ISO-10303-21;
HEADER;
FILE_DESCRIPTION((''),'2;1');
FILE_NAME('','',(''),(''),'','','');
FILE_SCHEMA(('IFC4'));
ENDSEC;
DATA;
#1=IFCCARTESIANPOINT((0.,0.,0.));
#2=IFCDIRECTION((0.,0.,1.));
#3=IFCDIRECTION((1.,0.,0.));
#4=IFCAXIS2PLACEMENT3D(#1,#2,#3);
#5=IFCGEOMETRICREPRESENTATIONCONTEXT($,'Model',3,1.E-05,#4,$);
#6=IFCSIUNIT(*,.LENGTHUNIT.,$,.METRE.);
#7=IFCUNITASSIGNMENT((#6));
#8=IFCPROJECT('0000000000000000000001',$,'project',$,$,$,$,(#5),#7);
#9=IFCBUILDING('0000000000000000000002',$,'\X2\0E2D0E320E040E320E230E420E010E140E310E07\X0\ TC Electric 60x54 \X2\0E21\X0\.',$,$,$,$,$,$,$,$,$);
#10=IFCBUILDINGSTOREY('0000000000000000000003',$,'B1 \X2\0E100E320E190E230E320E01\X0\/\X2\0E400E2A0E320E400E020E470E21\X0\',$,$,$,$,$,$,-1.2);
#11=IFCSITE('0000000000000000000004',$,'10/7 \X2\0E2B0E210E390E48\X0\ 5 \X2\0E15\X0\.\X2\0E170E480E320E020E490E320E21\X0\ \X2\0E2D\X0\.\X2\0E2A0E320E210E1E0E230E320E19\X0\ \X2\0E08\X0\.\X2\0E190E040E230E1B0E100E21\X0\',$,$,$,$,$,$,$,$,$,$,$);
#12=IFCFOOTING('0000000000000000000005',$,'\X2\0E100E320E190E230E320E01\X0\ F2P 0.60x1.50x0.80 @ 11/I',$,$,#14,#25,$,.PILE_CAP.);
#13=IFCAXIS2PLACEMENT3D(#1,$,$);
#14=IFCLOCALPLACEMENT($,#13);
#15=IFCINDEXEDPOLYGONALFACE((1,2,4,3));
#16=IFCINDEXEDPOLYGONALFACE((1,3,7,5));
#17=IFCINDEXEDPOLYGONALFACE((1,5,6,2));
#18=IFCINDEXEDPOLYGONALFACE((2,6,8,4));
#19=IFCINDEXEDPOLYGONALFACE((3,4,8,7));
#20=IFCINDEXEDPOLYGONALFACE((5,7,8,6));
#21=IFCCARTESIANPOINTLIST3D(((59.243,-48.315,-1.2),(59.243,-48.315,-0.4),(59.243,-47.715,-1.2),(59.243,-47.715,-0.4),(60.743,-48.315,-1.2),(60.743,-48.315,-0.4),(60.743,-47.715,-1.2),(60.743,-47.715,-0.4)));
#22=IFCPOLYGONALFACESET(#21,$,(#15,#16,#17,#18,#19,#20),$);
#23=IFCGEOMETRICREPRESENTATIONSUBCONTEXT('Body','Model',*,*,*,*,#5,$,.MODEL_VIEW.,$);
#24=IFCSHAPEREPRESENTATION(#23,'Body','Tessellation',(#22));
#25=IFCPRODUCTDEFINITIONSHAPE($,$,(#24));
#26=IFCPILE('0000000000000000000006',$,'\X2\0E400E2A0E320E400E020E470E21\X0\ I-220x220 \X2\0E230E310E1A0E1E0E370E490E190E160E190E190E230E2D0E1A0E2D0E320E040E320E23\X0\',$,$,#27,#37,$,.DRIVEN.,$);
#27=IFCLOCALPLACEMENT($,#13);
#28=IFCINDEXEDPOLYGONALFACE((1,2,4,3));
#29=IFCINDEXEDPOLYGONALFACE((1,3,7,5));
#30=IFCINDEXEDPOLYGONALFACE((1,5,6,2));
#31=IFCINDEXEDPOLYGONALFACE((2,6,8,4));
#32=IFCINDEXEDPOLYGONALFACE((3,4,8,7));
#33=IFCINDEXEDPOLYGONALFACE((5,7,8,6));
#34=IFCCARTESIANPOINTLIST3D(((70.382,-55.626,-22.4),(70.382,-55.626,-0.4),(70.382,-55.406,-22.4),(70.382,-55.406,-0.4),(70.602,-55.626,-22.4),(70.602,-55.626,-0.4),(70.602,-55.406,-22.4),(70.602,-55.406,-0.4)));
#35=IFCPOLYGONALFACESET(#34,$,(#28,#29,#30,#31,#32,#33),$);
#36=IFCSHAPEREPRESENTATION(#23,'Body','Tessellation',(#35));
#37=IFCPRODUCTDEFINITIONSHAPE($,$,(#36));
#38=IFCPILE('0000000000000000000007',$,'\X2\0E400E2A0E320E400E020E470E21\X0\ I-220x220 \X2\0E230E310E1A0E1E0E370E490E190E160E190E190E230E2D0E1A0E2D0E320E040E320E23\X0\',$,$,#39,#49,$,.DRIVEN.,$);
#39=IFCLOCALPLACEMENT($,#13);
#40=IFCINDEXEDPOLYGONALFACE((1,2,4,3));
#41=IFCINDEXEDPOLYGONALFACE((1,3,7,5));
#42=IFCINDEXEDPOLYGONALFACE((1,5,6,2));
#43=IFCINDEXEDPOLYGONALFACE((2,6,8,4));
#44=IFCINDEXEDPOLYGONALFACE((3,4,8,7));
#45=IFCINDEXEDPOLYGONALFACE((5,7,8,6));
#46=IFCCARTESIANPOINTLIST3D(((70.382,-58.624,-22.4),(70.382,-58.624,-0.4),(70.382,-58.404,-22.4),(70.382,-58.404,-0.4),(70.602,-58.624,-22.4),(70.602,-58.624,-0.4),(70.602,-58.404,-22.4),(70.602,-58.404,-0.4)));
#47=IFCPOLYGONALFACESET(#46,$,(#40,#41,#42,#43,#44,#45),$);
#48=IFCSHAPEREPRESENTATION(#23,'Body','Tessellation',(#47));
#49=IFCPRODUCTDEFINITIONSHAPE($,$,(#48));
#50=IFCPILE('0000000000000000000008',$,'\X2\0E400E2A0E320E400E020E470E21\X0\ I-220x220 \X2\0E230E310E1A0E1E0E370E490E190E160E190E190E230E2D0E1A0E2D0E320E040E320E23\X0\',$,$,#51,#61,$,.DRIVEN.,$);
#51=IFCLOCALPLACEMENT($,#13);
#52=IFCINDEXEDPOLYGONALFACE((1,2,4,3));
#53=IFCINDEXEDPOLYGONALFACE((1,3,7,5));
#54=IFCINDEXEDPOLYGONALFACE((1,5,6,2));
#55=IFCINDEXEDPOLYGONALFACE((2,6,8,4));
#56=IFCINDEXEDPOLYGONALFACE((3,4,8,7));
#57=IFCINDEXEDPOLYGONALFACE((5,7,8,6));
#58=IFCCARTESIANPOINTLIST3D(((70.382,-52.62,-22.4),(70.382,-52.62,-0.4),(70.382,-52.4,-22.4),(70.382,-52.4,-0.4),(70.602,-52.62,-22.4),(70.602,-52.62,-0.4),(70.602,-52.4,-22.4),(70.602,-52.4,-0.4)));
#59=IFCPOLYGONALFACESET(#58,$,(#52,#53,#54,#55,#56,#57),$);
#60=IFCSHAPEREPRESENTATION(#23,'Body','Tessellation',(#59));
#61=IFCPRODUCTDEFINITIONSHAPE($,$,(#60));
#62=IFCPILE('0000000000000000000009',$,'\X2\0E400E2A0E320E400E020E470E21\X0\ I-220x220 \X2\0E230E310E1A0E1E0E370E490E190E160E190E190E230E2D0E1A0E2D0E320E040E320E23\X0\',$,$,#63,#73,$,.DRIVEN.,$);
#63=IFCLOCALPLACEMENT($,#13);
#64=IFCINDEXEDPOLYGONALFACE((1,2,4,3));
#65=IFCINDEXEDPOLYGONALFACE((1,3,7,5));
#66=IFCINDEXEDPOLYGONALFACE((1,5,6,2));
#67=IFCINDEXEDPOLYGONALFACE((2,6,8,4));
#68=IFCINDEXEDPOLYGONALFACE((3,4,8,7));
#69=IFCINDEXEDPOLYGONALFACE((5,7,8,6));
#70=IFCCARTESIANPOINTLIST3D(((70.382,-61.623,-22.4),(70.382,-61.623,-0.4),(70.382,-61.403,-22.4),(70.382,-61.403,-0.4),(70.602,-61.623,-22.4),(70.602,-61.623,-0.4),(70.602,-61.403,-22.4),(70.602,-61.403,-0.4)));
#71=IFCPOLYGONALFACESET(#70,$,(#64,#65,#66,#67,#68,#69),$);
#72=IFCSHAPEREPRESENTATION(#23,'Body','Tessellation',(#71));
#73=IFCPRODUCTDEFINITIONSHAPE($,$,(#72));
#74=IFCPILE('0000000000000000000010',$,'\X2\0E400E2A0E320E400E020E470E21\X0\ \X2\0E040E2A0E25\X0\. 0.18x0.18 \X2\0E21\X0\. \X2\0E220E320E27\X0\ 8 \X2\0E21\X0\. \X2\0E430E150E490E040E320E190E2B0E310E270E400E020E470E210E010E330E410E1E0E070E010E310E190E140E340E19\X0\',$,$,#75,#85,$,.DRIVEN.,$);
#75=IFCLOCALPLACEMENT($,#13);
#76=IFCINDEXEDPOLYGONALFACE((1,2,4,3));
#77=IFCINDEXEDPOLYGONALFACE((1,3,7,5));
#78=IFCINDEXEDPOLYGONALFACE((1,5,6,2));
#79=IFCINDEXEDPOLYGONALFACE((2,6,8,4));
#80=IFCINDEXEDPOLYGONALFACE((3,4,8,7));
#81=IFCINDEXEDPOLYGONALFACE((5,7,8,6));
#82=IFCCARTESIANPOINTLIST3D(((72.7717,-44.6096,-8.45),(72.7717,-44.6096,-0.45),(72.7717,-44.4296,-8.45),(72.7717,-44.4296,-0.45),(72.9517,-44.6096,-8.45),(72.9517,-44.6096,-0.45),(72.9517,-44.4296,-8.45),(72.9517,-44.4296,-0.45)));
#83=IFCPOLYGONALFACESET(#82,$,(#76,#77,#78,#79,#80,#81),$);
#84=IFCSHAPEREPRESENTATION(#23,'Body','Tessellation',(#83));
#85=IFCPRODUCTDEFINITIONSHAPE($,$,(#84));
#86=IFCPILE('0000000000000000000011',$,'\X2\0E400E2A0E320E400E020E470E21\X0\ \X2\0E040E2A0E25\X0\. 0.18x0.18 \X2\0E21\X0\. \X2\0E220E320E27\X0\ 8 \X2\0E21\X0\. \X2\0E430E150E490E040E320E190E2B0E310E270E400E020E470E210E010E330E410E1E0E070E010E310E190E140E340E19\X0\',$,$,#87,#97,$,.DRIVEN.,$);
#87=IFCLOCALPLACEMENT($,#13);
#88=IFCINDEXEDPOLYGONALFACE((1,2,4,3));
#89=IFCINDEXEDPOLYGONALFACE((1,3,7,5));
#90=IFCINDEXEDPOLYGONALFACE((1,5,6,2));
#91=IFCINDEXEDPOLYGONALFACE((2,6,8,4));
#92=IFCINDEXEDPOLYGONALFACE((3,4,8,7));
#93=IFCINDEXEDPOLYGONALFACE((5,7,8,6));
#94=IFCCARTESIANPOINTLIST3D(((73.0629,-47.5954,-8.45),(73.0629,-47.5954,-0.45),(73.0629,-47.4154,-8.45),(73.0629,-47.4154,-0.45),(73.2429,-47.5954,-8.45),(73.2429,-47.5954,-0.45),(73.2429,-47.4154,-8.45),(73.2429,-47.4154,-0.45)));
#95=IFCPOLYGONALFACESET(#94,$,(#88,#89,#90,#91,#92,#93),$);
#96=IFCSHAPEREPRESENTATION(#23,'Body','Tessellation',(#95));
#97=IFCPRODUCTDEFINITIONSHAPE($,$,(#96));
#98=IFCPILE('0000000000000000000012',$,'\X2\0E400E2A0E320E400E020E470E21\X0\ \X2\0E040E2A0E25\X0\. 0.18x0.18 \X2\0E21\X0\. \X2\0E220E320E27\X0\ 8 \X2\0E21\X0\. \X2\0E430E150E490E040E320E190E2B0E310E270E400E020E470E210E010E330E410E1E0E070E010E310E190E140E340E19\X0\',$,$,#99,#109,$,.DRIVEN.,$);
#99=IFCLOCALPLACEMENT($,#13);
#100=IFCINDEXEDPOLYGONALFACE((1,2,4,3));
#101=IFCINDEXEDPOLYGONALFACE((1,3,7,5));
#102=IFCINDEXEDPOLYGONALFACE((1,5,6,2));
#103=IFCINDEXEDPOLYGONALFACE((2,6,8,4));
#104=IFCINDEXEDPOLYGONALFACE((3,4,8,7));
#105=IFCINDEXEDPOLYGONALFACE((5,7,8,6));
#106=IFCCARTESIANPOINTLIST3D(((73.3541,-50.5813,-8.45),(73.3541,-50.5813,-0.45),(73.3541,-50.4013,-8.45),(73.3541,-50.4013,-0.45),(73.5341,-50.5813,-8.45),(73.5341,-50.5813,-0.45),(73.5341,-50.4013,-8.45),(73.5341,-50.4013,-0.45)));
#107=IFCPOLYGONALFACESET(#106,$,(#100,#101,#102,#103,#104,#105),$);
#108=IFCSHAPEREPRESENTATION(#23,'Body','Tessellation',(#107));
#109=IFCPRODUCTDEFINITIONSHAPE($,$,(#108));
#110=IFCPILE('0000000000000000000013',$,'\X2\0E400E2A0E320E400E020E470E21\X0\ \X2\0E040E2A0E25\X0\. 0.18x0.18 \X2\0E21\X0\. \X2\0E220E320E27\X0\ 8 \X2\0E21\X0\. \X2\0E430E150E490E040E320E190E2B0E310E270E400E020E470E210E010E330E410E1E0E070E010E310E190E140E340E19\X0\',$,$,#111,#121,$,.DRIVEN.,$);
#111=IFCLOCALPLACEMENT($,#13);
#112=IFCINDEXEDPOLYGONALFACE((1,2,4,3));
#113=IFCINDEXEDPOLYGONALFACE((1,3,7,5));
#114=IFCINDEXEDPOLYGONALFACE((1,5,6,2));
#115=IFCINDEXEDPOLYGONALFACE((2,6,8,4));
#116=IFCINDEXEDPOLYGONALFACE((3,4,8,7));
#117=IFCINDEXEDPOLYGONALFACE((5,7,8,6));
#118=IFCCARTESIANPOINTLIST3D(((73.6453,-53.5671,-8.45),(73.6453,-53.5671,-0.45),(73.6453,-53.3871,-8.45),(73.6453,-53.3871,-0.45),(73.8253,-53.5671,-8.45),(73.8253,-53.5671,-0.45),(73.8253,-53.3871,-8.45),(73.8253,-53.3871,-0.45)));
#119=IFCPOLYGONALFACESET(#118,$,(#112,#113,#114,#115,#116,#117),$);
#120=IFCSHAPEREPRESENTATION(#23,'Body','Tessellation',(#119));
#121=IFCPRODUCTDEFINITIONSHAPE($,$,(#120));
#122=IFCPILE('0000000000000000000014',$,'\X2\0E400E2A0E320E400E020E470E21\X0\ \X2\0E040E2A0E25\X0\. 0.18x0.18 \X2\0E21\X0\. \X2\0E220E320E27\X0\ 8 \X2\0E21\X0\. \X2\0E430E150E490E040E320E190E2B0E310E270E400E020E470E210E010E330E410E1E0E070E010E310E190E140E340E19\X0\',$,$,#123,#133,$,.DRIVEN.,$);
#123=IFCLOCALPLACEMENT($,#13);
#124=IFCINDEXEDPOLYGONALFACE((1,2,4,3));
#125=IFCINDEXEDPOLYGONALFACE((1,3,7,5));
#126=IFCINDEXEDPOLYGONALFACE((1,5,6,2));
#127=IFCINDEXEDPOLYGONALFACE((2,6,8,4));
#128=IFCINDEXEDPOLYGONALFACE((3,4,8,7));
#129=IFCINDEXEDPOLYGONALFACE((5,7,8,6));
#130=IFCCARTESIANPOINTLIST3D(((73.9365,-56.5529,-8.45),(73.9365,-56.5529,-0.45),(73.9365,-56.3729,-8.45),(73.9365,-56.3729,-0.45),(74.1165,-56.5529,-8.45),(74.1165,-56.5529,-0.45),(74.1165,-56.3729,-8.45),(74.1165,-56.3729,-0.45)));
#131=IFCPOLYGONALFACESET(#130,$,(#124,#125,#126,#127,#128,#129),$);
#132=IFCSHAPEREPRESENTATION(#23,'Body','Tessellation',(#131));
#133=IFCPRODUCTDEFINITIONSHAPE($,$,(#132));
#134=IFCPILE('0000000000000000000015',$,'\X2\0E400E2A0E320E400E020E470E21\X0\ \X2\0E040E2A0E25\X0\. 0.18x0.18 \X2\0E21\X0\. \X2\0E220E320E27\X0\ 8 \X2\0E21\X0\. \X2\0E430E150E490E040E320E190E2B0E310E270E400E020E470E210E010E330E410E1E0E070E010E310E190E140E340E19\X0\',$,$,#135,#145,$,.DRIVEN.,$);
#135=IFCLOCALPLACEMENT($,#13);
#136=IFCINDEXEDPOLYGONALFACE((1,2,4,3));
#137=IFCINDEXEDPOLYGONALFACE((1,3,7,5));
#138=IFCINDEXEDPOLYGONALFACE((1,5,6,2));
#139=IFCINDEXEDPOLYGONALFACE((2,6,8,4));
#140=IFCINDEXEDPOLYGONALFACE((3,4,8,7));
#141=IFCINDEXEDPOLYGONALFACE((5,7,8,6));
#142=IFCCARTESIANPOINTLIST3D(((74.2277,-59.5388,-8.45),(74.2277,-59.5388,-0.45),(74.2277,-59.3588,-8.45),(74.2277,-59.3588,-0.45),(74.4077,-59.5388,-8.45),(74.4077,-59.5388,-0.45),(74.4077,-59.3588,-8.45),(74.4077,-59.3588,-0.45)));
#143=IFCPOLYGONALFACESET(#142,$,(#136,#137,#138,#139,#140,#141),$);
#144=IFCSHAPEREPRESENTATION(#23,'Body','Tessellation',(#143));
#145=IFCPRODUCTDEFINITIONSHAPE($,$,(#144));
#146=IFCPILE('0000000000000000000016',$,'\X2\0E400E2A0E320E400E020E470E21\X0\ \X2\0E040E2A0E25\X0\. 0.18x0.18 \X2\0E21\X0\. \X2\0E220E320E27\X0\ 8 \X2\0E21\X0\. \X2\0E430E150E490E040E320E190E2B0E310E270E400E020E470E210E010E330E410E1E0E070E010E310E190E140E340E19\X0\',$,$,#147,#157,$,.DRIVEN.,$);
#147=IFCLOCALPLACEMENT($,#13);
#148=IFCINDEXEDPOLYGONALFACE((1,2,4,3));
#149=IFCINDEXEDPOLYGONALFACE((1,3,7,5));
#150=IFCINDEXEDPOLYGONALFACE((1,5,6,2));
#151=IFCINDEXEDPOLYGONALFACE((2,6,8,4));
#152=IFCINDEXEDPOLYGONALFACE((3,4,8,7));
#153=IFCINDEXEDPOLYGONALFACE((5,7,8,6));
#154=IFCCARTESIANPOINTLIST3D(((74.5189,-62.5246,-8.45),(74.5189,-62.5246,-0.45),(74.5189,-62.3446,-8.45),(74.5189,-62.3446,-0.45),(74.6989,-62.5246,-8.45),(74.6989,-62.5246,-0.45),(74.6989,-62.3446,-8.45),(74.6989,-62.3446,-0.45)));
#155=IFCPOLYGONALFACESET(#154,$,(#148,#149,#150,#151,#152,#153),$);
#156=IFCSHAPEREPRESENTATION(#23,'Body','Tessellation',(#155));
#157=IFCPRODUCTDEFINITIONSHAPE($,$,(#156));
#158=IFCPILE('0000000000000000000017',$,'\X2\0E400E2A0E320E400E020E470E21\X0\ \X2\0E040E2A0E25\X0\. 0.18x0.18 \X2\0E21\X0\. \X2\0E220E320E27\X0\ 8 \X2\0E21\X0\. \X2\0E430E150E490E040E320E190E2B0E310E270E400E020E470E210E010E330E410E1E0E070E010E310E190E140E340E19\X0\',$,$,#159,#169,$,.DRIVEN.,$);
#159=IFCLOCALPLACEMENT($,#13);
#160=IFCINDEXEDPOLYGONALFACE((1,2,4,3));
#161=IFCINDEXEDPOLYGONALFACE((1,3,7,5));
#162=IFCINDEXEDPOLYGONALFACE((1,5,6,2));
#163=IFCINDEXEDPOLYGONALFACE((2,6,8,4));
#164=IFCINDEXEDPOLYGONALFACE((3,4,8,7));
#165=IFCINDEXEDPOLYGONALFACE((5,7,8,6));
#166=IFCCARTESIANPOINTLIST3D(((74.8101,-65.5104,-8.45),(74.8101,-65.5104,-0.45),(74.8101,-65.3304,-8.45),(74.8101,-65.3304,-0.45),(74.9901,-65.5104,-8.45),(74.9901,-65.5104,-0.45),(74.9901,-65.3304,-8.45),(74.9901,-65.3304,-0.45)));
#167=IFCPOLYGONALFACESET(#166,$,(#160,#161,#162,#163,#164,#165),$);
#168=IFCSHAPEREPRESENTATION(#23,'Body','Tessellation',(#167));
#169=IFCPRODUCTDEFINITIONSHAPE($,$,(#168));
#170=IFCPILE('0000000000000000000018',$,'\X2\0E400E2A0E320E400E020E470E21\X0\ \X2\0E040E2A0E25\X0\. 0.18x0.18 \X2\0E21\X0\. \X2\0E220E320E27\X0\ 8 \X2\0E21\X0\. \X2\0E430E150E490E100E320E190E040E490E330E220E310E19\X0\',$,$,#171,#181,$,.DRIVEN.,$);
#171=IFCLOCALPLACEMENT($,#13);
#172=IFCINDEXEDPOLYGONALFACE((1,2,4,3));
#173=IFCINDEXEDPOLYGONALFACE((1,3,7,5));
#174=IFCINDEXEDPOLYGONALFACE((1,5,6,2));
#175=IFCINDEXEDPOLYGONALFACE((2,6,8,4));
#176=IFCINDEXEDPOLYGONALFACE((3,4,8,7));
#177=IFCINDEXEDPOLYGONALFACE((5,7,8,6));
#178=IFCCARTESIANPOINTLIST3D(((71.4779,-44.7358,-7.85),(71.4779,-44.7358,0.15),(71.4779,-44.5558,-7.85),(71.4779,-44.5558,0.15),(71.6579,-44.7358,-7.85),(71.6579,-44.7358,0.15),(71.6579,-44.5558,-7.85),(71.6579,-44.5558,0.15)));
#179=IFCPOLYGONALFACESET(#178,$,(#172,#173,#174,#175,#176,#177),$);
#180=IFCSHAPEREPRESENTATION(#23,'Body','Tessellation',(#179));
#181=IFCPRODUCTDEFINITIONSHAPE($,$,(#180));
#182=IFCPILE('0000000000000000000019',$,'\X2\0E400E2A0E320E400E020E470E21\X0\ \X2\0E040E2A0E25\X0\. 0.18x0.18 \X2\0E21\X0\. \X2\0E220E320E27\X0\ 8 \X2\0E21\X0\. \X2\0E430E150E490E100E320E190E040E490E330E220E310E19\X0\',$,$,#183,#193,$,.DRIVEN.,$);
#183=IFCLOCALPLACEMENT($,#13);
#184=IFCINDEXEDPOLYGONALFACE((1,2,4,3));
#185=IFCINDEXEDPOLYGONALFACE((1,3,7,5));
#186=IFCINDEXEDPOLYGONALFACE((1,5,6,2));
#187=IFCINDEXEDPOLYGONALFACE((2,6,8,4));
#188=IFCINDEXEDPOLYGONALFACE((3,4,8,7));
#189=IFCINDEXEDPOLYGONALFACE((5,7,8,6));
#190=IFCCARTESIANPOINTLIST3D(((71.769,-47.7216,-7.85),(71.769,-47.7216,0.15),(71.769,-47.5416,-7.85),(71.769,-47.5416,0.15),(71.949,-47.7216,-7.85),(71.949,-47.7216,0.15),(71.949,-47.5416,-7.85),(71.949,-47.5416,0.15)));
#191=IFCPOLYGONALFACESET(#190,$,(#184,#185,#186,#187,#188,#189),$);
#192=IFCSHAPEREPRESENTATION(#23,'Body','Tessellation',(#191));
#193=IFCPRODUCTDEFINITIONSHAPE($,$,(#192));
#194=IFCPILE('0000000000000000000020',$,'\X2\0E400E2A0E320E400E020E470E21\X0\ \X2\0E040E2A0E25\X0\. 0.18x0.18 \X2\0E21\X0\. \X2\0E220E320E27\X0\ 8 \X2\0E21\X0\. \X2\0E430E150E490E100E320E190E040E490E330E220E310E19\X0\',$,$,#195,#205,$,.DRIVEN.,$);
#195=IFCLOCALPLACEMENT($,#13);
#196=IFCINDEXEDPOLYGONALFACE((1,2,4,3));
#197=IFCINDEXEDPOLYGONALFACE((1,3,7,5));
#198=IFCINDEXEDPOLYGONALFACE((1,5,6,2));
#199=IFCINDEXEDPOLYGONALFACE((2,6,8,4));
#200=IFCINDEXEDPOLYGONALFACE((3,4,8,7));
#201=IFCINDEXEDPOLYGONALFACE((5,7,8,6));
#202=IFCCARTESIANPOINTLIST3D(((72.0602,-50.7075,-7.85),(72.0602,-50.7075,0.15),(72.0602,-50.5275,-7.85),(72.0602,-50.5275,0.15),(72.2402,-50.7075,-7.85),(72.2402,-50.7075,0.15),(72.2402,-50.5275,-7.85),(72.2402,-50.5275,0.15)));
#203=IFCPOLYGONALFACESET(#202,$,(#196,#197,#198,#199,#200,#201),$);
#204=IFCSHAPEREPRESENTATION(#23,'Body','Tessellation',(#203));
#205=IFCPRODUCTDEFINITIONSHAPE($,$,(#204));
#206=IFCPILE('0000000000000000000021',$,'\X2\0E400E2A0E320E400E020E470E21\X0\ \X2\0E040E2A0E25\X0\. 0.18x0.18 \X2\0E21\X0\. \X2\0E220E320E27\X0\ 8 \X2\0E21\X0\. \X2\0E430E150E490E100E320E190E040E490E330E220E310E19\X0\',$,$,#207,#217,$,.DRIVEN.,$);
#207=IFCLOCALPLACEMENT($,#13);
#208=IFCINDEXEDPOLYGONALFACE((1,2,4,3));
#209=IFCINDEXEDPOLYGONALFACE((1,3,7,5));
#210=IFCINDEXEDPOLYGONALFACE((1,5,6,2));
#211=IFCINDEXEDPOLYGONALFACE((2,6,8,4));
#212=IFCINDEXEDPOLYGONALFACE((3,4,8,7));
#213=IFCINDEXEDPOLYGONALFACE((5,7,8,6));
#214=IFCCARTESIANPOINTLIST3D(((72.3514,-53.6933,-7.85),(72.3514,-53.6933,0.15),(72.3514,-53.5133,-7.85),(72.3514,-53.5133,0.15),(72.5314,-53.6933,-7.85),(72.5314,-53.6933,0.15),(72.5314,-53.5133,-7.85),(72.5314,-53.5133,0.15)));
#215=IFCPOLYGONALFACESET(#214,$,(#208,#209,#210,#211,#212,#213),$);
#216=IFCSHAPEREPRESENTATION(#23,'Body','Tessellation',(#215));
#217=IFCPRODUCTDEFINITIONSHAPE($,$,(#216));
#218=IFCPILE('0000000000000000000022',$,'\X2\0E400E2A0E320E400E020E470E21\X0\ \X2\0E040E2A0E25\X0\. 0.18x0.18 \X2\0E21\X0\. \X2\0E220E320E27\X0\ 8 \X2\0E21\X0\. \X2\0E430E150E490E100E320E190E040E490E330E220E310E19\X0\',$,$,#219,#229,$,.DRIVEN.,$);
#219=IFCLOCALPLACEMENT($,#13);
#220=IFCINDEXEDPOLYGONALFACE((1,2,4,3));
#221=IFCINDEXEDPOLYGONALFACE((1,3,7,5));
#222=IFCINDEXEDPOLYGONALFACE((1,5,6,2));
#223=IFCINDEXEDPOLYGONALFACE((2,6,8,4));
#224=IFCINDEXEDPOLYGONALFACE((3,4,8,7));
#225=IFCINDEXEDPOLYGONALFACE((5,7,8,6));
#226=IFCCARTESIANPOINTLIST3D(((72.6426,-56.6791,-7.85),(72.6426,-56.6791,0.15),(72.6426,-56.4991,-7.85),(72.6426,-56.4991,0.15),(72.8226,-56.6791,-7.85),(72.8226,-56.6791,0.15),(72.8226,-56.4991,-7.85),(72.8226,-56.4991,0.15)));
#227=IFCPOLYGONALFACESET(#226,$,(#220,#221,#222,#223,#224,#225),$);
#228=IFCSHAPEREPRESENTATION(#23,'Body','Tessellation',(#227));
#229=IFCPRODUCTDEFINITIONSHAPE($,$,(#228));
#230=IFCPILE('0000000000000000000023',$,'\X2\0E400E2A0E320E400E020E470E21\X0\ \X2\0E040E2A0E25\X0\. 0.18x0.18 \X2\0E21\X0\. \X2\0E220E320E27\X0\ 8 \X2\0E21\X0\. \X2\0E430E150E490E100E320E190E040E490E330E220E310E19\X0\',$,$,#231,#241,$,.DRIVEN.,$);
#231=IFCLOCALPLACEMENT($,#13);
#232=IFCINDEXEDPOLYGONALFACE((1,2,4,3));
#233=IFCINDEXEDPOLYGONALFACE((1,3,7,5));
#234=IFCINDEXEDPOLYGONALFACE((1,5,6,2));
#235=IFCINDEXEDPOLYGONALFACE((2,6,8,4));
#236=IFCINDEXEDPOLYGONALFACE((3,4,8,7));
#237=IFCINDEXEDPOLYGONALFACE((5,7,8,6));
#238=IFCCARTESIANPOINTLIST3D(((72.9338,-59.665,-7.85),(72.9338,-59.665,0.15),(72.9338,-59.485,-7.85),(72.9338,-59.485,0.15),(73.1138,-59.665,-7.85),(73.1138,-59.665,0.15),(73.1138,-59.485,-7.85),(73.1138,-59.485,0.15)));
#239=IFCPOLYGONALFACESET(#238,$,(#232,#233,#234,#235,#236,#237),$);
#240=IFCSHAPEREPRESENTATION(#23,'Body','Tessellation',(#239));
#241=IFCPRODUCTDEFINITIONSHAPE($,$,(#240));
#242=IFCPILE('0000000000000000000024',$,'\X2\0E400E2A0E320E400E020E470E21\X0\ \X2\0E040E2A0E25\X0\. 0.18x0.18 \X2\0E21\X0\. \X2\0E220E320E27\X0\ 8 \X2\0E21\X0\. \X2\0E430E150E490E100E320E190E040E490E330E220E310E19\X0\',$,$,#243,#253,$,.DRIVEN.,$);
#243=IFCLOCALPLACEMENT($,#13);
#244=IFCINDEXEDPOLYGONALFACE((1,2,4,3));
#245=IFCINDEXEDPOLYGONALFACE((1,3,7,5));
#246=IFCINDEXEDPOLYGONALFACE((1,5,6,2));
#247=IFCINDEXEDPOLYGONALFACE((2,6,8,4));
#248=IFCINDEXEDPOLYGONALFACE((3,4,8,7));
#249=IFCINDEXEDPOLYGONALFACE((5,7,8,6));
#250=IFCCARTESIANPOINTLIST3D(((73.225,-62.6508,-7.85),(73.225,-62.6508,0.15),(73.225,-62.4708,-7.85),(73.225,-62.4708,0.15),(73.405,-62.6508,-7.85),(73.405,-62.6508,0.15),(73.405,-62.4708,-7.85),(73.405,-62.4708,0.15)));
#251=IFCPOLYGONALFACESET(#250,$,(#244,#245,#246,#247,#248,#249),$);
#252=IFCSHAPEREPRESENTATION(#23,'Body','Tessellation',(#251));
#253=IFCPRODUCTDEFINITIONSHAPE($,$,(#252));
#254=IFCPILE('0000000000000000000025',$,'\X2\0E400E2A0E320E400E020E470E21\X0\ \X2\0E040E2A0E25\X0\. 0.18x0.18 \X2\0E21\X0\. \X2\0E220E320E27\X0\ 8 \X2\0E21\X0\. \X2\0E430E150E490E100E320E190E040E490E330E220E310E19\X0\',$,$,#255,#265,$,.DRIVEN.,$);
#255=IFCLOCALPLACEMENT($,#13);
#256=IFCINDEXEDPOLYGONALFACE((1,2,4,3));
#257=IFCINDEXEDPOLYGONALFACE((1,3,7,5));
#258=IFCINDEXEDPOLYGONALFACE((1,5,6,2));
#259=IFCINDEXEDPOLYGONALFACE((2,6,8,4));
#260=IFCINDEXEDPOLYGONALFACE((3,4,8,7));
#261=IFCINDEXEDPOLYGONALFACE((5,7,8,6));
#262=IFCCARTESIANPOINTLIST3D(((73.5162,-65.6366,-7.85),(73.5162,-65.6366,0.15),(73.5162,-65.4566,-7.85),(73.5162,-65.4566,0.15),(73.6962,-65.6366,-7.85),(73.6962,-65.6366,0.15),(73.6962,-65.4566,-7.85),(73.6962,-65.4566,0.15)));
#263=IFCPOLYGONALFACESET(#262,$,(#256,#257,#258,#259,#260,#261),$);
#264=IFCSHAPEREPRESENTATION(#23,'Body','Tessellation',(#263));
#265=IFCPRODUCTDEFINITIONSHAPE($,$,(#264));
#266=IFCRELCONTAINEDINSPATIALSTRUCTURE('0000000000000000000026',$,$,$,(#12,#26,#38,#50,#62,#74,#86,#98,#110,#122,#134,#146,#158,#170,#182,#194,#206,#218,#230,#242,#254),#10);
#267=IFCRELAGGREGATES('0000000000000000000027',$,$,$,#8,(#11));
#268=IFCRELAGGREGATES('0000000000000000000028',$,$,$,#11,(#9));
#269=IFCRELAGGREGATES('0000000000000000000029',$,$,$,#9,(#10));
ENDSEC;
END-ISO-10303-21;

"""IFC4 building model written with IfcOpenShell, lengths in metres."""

from ifc_helpers import new_model, si_unit, frame, origin, origin_with_axes, origin_2d, place, context, subcontext, project, spatial, rectangle, extrude, element, save


model = new_model("IFC4")

# Units and contexts
model_context = context("Model", 3, precision=1e-05, world=origin_with_axes())
body_context = subcontext(model_context, "Body", "Model", "MODEL_VIEW")
ifc_project = project(units=[si_unit("LENGTHUNIT", "METRE")], contexts=[model_context])

# Site, building, storey
site = spatial("IfcSite", under=ifc_project, Name="10/7 หมู่ 5 ต.ท่าข้าม อ.สามพราน จ.นครปฐม")
building = spatial("IfcBuilding", under=site, Name="อาคารโกดัง TC Electric 60x54 ม.")
storey = spatial("IfcBuildingStorey", under=building, Name="B1 ฐานราก/เสาเข็ม", Elevation=-1.2)

# Footing
footing_placement = place(None, frame((59.993, -48.015, -1.2), z_axis=(0.0, 0.0, 1.0), x_axis=(1.0, 0.0, 0.0)))
element("IfcFooting", 1, at=footing_placement, inside=storey, Name="ฐานราก F2P 0.60x1.50x0.80 @ 11/I", PredefinedType="PILE_CAP", context=body_context, shape_type="SweptSolid", body=[
    extrude(rectangle(XDim=1.5, YDim=0.6, at=origin_2d()), origin(), (0.0, 0.0, 1.0), 0.8),
])

# Piles
for number, where, z_axis, x_axis, name in (
    (2, (70.492, -55.516, -22.4), (0.0, 0.0, 1.0), (1.0, 0.0, 0.0), "เสาเข็ม I-220x220 รับพื้นถนนรอบอาคาร"),
    (3, (70.492, -58.514, -22.4), (0.0, 0.0, 1.0), (1.0, 0.0, 0.0), "เสาเข็ม I-220x220 รับพื้นถนนรอบอาคาร"),
    (4, (70.492, -52.51, -22.4), (0.0, 0.0, 1.0), (1.0, 0.0, 0.0), "เสาเข็ม I-220x220 รับพื้นถนนรอบอาคาร"),
    (5, (70.492, -61.513, -22.4), (0.0, 0.0, 1.0), (1.0, 0.0, 0.0), "เสาเข็ม I-220x220 รับพื้นถนนรอบอาคาร"),
):
    element("IfcPile", number, at=place(None, frame(where, z_axis=z_axis, x_axis=x_axis)), inside=storey, Name=name, PredefinedType="DRIVEN", context=body_context, shape_type="SweptSolid", body=[
        extrude(rectangle(XDim=0.22, YDim=0.22, at=origin_2d()), origin(), (0.0, 0.0, 1.0), 22.0),
    ])
for number, where, z_axis, x_axis, name in (
    (6, (72.8617, -44.5196, -8.45), (0.0, 0.0, 1.0), (1.0, 0.0, 0.0), "เสาเข็ม คสล. 0.18x0.18 ม. ยาว 8 ม. ใต้คานหัวเข็มกำแพงกันดิน"),
    (7, (73.1529, -47.5054, -8.45), (0.0, 0.0, 1.0), (1.0, 0.0, 0.0), "เสาเข็ม คสล. 0.18x0.18 ม. ยาว 8 ม. ใต้คานหัวเข็มกำแพงกันดิน"),
    (8, (73.4441, -50.4913, -8.45), (0.0, 0.0, 1.0), (1.0, 0.0, 0.0), "เสาเข็ม คสล. 0.18x0.18 ม. ยาว 8 ม. ใต้คานหัวเข็มกำแพงกันดิน"),
    (9, (73.7353, -53.4771, -8.45), (0.0, 0.0, 1.0), (1.0, 0.0, 0.0), "เสาเข็ม คสล. 0.18x0.18 ม. ยาว 8 ม. ใต้คานหัวเข็มกำแพงกันดิน"),
    (10, (74.0265, -56.4629, -8.45), (0.0, 0.0, 1.0), (1.0, 0.0, 0.0), "เสาเข็ม คสล. 0.18x0.18 ม. ยาว 8 ม. ใต้คานหัวเข็มกำแพงกันดิน"),
    (11, (74.3177, -59.4488, -8.45), (0.0, 0.0, 1.0), (1.0, 0.0, 0.0), "เสาเข็ม คสล. 0.18x0.18 ม. ยาว 8 ม. ใต้คานหัวเข็มกำแพงกันดิน"),
    (12, (74.6089, -62.4346, -8.45), (0.0, 0.0, 1.0), (1.0, 0.0, 0.0), "เสาเข็ม คสล. 0.18x0.18 ม. ยาว 8 ม. ใต้คานหัวเข็มกำแพงกันดิน"),
    (13, (74.9001, -65.4204, -8.45), (0.0, 0.0, 1.0), (1.0, 0.0, 0.0), "เสาเข็ม คสล. 0.18x0.18 ม. ยาว 8 ม. ใต้คานหัวเข็มกำแพงกันดิน"),
    (14, (71.5679, -44.6458, -7.85), (0.0, 0.0, 1.0), (1.0, 0.0, 0.0), "เสาเข็ม คสล. 0.18x0.18 ม. ยาว 8 ม. ใต้ฐานค้ำยัน"),
    (15, (71.859, -47.6316, -7.85), (0.0, 0.0, 1.0), (1.0, 0.0, 0.0), "เสาเข็ม คสล. 0.18x0.18 ม. ยาว 8 ม. ใต้ฐานค้ำยัน"),
    (16, (72.1502, -50.6175, -7.85), (0.0, 0.0, 1.0), (1.0, 0.0, 0.0), "เสาเข็ม คสล. 0.18x0.18 ม. ยาว 8 ม. ใต้ฐานค้ำยัน"),
    (17, (72.4414, -53.6033, -7.85), (0.0, 0.0, 1.0), (1.0, 0.0, 0.0), "เสาเข็ม คสล. 0.18x0.18 ม. ยาว 8 ม. ใต้ฐานค้ำยัน"),
    (18, (72.7326, -56.5891, -7.85), (0.0, 0.0, 1.0), (1.0, 0.0, 0.0), "เสาเข็ม คสล. 0.18x0.18 ม. ยาว 8 ม. ใต้ฐานค้ำยัน"),
    (19, (73.0238, -59.575, -7.85), (0.0, 0.0, 1.0), (1.0, 0.0, 0.0), "เสาเข็ม คสล. 0.18x0.18 ม. ยาว 8 ม. ใต้ฐานค้ำยัน"),
    (20, (73.315, -62.5608, -7.85), (0.0, 0.0, 1.0), (1.0, 0.0, 0.0), "เสาเข็ม คสล. 0.18x0.18 ม. ยาว 8 ม. ใต้ฐานค้ำยัน"),
    (21, (73.6062, -65.5466, -7.85), (0.0, 0.0, 1.0), (1.0, 0.0, 0.0), "เสาเข็ม คสล. 0.18x0.18 ม. ยาว 8 ม. ใต้ฐานค้ำยัน"),
):
    element("IfcPile", number, at=place(None, frame(where, z_axis=z_axis, x_axis=x_axis)), inside=storey, Name=name, PredefinedType="DRIVEN", context=body_context, shape_type="SweptSolid", body=[
        extrude(rectangle(XDim=0.18, YDim=0.18, at=origin_2d()), origin(), (0.0, 0.0, 1.0), 8.0),
    ])

save(model, "model.ifc")
